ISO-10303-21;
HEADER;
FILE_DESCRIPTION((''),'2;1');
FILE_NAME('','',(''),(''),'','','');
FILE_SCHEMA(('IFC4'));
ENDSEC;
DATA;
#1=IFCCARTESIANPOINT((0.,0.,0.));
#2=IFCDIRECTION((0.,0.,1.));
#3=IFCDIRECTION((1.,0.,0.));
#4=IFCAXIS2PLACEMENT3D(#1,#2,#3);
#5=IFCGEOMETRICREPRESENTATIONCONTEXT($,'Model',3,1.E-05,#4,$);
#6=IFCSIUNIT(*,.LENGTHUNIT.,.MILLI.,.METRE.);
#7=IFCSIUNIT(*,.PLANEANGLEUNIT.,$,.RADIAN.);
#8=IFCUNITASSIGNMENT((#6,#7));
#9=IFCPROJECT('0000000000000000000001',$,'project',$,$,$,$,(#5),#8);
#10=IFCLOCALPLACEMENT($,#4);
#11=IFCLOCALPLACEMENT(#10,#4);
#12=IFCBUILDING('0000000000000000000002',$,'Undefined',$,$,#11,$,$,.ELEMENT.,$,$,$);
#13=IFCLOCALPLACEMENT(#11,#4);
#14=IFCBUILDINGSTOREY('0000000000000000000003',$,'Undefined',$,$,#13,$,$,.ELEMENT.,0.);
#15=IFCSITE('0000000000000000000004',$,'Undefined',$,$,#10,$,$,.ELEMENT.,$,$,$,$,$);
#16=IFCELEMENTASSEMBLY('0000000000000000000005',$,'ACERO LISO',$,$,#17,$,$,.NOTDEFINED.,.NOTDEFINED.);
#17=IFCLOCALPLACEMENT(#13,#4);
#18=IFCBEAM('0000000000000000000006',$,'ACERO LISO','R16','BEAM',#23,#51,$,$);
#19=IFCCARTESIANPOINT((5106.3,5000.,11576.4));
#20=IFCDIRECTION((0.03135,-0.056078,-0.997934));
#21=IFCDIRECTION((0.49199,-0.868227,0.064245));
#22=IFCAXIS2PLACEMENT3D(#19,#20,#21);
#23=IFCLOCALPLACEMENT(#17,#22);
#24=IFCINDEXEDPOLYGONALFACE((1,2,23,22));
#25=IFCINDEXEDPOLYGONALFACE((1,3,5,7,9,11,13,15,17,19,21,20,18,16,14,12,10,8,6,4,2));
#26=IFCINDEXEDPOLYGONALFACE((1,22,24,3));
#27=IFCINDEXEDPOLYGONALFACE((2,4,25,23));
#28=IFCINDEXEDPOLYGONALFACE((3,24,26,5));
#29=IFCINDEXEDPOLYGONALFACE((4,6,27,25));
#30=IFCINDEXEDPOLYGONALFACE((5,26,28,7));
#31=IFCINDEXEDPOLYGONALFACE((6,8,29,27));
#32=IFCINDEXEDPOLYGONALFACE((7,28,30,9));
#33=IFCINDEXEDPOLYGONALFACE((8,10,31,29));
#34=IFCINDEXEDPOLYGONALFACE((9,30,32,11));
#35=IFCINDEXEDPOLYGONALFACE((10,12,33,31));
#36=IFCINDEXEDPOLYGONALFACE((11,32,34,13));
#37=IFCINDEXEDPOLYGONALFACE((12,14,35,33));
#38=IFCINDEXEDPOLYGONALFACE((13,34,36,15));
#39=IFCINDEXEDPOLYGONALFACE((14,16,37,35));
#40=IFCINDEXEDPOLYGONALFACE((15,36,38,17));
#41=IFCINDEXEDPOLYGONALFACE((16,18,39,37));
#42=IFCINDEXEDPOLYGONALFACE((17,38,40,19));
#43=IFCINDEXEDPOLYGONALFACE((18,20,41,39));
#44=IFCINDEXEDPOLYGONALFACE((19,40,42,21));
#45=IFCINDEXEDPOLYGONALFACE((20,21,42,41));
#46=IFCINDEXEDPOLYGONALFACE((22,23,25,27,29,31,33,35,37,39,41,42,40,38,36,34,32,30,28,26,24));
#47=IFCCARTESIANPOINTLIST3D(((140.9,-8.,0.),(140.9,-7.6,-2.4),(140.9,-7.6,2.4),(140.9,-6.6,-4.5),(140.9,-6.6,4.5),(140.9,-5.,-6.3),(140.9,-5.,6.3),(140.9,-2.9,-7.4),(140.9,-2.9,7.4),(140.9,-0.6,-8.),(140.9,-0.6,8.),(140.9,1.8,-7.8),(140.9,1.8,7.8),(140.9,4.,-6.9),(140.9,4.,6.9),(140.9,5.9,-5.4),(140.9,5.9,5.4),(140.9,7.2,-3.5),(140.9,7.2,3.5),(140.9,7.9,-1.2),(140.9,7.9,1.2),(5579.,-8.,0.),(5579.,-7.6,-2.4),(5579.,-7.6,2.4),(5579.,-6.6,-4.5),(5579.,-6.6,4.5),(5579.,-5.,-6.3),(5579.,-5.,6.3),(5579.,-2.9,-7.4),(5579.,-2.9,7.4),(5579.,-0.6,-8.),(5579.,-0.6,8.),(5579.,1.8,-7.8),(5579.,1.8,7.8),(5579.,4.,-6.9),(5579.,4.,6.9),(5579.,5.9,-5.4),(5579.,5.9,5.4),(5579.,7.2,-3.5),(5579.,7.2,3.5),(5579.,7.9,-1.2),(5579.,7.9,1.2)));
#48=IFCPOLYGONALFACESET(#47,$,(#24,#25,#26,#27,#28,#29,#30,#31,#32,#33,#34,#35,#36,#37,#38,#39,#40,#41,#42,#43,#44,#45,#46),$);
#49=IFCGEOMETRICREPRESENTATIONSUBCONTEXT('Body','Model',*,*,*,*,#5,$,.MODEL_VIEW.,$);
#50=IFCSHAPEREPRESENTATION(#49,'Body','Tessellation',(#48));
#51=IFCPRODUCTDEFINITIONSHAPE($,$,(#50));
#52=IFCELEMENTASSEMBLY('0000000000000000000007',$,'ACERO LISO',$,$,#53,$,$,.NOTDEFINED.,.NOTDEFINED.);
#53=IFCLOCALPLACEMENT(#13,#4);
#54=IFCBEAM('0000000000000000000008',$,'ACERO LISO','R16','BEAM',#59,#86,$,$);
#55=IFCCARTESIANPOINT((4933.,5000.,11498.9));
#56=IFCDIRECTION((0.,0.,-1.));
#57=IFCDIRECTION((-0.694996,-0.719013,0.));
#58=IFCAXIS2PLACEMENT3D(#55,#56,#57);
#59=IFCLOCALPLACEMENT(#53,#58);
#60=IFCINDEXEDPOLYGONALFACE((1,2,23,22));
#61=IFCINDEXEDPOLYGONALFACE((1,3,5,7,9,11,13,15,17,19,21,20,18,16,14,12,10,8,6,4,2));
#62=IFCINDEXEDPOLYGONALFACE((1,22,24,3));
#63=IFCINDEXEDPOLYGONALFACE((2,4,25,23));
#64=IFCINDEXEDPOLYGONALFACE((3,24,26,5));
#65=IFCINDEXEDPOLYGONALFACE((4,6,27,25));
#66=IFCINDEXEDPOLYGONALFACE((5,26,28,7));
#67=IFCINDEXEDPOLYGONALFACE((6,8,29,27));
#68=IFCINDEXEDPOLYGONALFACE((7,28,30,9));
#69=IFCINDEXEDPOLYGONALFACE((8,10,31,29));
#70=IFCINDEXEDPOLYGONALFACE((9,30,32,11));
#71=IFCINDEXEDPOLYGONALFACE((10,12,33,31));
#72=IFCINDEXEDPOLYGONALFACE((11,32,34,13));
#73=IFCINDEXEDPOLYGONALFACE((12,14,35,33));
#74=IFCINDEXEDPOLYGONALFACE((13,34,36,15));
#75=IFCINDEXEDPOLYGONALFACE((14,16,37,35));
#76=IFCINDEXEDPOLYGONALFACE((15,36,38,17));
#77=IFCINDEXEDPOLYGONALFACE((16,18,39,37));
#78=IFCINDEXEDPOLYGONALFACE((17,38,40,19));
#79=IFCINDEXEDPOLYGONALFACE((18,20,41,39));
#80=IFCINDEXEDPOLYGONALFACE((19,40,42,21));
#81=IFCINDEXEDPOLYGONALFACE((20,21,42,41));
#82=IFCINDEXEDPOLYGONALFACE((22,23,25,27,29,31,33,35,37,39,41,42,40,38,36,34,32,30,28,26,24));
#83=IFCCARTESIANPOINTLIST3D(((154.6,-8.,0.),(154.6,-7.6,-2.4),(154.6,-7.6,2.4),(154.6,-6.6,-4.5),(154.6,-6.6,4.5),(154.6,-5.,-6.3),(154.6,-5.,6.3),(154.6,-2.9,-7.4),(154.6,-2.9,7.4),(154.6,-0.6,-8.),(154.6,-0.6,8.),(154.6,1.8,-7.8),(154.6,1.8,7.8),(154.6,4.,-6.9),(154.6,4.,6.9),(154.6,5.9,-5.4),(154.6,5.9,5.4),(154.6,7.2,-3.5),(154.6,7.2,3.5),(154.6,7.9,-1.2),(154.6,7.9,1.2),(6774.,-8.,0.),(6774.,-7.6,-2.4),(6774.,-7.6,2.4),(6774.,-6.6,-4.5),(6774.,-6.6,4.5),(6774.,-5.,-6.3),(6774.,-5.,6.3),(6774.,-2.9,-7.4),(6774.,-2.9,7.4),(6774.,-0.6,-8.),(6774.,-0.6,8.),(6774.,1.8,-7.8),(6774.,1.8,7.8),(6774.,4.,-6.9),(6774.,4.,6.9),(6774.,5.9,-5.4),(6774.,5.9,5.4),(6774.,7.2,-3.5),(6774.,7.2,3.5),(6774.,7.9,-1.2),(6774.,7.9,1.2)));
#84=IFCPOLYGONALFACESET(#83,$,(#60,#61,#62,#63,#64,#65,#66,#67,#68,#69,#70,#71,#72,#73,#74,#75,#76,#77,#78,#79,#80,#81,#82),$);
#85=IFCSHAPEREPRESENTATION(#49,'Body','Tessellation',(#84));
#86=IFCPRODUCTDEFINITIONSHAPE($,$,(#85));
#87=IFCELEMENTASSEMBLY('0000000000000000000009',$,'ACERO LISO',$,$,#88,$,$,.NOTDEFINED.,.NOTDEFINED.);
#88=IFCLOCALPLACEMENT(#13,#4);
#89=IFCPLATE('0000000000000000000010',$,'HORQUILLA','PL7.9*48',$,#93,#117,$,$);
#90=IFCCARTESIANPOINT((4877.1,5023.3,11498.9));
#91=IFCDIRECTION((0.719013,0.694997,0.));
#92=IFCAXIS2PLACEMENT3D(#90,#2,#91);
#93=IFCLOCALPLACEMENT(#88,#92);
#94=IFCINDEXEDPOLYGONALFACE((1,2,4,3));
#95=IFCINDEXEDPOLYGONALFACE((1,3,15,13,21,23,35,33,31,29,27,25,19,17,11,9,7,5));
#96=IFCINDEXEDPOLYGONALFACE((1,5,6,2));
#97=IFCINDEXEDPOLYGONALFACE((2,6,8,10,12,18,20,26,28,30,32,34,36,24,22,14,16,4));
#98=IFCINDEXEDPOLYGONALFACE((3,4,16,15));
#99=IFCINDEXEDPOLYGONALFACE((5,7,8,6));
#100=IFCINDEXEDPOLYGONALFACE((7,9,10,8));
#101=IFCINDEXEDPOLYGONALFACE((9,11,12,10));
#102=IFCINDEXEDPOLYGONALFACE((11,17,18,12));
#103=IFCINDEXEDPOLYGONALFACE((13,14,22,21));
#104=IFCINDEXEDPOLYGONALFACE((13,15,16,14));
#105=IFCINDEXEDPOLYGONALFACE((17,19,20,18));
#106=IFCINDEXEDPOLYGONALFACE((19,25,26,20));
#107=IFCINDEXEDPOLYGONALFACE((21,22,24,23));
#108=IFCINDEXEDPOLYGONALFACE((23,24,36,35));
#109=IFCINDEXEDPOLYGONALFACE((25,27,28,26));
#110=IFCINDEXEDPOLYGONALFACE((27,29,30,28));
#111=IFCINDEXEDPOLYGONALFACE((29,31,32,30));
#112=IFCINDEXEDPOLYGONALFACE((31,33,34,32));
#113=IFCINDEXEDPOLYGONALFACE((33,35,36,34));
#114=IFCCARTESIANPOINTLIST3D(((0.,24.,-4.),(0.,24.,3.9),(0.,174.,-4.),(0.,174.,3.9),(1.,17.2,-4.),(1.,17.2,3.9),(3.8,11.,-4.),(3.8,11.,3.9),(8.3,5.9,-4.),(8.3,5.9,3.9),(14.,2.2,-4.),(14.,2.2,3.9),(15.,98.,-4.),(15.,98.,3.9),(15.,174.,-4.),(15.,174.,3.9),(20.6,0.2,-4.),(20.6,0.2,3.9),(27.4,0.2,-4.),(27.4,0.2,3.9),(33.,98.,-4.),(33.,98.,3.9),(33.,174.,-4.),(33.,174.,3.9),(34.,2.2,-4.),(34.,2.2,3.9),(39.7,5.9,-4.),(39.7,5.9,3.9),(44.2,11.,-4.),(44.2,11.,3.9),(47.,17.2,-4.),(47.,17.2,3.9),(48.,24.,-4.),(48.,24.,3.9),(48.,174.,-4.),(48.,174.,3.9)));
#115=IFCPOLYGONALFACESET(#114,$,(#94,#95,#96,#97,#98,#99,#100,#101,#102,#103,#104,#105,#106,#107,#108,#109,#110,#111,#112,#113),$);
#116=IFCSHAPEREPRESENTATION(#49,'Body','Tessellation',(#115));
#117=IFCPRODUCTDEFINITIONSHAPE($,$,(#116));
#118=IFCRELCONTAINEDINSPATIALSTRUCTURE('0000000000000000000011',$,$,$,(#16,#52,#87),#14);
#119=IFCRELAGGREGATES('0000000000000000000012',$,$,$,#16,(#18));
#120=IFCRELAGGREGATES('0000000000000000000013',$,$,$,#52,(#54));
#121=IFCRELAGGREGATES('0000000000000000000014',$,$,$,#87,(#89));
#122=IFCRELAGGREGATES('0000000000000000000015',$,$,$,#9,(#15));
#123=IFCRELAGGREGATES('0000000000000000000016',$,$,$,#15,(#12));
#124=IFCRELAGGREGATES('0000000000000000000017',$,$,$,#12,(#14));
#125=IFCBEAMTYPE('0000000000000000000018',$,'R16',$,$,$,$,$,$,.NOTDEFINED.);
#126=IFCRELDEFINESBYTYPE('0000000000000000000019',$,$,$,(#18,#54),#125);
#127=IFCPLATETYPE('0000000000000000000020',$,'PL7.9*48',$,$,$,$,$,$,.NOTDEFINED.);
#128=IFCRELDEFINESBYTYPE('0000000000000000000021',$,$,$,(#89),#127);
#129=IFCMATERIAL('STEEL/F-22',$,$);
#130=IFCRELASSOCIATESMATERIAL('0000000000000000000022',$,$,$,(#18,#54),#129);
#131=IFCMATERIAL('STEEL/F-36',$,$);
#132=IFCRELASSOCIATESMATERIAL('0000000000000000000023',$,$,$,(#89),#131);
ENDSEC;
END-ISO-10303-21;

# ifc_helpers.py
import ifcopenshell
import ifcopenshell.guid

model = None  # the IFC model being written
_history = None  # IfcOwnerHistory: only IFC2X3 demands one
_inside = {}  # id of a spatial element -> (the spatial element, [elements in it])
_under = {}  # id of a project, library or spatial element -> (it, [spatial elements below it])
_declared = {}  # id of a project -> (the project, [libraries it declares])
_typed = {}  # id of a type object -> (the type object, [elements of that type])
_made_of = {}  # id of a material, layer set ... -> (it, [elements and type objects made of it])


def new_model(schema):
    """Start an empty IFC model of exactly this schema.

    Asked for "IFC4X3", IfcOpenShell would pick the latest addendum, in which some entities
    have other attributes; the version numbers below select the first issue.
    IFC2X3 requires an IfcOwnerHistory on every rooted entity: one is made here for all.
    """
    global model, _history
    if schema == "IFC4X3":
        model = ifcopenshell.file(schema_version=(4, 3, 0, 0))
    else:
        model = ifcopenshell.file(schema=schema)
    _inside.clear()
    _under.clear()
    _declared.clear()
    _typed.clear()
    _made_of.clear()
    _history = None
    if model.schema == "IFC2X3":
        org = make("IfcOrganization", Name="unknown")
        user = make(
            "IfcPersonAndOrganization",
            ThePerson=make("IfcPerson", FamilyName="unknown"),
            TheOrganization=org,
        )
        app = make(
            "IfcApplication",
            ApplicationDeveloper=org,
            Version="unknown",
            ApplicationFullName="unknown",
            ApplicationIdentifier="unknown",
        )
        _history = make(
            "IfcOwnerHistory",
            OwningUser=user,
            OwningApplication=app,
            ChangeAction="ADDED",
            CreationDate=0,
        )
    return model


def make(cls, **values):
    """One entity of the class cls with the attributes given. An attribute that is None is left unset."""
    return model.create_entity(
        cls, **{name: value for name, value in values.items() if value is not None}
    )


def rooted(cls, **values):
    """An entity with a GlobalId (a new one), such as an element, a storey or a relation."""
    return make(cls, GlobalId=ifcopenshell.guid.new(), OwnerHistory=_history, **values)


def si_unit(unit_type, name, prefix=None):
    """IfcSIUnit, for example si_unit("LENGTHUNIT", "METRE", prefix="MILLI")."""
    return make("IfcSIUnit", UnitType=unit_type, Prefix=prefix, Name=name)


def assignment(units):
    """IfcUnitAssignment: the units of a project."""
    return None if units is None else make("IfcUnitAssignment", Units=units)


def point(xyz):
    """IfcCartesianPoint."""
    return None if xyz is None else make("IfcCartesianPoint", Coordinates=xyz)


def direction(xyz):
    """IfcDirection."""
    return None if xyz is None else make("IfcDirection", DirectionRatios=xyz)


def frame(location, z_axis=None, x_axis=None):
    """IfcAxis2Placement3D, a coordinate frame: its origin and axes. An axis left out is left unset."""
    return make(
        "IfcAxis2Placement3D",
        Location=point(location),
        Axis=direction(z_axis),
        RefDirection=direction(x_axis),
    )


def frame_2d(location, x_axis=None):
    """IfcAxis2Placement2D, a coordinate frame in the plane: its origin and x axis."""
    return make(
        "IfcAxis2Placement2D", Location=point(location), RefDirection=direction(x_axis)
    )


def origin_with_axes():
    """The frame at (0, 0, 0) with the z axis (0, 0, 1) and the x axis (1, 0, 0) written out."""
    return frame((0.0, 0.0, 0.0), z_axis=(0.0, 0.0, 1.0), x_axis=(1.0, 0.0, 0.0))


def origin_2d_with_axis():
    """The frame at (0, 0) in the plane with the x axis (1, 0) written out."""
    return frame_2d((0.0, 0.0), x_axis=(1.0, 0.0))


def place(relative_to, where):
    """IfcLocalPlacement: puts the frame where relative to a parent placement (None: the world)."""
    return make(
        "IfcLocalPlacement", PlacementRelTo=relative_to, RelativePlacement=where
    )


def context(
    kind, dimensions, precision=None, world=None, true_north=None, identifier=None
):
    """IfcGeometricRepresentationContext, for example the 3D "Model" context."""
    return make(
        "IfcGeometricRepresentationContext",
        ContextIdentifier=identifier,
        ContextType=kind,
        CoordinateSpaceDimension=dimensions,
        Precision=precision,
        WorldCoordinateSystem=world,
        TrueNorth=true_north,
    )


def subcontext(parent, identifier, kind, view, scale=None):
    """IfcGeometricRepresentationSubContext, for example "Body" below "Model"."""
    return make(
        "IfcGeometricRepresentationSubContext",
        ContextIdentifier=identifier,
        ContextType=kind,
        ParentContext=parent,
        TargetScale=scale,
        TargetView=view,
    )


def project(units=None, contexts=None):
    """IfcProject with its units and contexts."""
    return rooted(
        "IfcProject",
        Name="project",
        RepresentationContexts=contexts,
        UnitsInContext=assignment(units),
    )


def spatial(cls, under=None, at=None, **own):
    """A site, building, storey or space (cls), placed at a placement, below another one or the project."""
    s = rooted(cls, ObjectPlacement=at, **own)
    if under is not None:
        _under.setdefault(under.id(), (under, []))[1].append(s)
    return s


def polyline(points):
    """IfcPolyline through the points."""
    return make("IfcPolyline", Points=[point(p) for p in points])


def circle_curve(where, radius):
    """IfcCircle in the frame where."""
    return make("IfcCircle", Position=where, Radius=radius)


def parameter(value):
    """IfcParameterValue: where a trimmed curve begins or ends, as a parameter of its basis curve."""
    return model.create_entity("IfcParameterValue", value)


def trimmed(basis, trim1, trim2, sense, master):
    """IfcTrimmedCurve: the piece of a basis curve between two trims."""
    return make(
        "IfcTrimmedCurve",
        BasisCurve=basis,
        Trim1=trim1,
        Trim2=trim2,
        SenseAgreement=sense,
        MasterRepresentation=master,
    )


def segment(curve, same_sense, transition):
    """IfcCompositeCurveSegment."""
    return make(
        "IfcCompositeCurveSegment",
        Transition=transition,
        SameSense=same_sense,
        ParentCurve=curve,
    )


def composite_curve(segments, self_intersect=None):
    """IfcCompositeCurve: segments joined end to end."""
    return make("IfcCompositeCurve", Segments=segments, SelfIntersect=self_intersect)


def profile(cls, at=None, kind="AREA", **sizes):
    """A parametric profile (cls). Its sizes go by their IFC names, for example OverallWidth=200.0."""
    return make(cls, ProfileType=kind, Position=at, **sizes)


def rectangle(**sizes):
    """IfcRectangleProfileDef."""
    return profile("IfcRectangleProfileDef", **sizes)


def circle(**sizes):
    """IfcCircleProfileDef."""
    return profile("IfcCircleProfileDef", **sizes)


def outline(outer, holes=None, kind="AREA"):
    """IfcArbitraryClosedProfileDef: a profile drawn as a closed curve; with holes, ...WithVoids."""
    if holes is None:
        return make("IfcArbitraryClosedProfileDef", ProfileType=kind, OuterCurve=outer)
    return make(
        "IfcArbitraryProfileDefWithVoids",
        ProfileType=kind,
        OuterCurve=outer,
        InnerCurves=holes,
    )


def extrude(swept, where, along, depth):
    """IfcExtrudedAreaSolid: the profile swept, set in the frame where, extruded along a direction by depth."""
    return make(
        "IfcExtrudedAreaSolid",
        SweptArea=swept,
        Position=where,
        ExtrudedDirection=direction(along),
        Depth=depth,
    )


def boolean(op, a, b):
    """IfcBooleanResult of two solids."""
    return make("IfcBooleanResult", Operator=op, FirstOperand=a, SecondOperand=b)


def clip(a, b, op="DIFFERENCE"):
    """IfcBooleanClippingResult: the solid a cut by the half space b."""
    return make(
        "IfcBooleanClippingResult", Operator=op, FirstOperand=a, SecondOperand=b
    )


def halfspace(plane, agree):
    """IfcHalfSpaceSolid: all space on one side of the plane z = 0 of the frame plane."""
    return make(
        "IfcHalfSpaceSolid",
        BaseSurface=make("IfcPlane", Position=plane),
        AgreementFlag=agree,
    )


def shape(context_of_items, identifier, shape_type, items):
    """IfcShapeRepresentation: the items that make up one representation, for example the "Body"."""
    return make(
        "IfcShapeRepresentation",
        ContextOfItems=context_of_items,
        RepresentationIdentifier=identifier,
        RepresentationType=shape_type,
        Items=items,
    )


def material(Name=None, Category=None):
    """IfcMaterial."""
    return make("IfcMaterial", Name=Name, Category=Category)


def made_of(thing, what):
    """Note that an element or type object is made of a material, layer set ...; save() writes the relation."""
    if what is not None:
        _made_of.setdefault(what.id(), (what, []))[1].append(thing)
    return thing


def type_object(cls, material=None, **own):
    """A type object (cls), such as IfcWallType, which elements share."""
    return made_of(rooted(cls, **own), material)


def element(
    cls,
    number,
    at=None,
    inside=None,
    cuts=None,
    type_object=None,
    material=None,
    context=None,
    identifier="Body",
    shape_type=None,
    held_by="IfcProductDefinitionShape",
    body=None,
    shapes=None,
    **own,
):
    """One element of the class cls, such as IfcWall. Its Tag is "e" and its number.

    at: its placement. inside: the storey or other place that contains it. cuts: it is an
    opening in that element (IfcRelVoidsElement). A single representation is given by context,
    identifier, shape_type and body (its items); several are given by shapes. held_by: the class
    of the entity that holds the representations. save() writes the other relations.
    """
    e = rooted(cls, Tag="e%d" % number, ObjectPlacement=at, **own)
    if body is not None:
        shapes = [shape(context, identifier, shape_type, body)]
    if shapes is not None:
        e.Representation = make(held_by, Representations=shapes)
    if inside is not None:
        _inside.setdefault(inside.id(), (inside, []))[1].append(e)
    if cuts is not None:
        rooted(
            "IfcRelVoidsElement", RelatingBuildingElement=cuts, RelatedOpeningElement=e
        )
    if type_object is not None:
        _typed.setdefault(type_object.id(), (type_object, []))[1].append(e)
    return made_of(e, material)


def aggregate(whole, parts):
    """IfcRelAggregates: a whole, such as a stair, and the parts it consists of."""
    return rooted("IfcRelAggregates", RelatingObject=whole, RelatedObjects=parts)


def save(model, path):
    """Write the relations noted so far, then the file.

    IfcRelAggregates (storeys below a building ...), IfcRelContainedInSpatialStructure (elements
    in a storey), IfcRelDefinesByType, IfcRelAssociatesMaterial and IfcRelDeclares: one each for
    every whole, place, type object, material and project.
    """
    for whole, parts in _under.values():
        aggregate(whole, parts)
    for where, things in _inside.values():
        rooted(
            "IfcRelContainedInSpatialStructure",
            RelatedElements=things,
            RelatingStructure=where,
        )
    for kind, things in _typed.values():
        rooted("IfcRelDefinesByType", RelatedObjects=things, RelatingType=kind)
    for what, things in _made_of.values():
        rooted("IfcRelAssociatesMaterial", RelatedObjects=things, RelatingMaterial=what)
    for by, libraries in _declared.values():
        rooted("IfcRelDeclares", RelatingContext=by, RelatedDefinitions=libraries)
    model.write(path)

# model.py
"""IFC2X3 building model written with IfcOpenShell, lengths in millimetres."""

from ifc_helpers import new_model, si_unit, frame, frame_2d, origin_with_axes, origin_2d_with_axis, place, context, subcontext, project, spatial, polyline, circle_curve, parameter, trimmed, segment, composite_curve, rectangle, circle, outline, extrude, boolean, clip, halfspace, material, type_object, element, aggregate, save


model = new_model("IFC2X3")

# Units and contexts
model_context = context("Model", 3, precision=1e-05, world=origin_with_axes())
body_context = subcontext(model_context, "Body", "Model", "MODEL_VIEW")
ifc_project = project(units=[si_unit("LENGTHUNIT", "METRE", prefix="MILLI"), si_unit("PLANEANGLEUNIT", "RADIAN")], contexts=[model_context])

# Site, building, storey
site_placement = place(None, origin_with_axes())
site = spatial("IfcSite", under=ifc_project, at=site_placement, Name="Undefined", CompositionType="ELEMENT")
building_placement = place(site_placement, origin_with_axes())
building = spatial("IfcBuilding", under=site, at=building_placement, Name="Undefined", CompositionType="ELEMENT")
storey_placement = place(building_placement, origin_with_axes())
storey = spatial("IfcBuildingStorey", under=building, at=storey_placement, Name="Undefined", CompositionType="ELEMENT", Elevation=0.0)

# Element assemblies, beams
assembly_1_placement = place(storey_placement, origin_with_axes())
assembly_1 = element("IfcElementAssembly", 1, at=assembly_1_placement, inside=storey, Name="ACERO LISO", AssemblyPlace="NOTDEFINED", PredefinedType="NOTDEFINED")
ifc_material_1 = material(Name="STEEL/F-22")
beam_type_1 = type_object("IfcBeamType", Name="R16", PredefinedType="NOTDEFINED")
beam_1_placement = place(assembly_1_placement, frame((5106.3, 5000.0, 11576.4), z_axis=(0.03135, -0.056078, -0.997934), x_axis=(0.49199, -0.868227, 0.064245)))
beam_1 = element("IfcBeam", 2, at=beam_1_placement, type_object=beam_type_1, material=ifc_material_1, Name="ACERO LISO", Description="R16", ObjectType="BEAM", context=body_context, shape_type="Clipping", body=[
    clip(extrude(circle(Radius=8.0, at=origin_2d_with_axis()), frame((5579.0, 0.0, 0.0), z_axis=(-1.0, 0.0, 0.0), x_axis=(0.0, -1.0, 0.0)), (0.0, 0.0, 1.0), 5579.0), halfspace(frame((140.9, 0.0, 0.0), z_axis=(1.0, 0.0, 0.0), x_axis=(0.0, -0.097702, 0.995216)), True)),
])
aggregate(assembly_1, [beam_1])
assembly_2_placement = place(storey_placement, origin_with_axes())
assembly_2 = element("IfcElementAssembly", 3, at=assembly_2_placement, inside=storey, Name="ACERO LISO", AssemblyPlace="NOTDEFINED", PredefinedType="NOTDEFINED")
beam_2_placement = place(assembly_2_placement, frame((4933.0, 5000.0, 11498.9), z_axis=(0.0, 0.0, -1.0), x_axis=(-0.694996, -0.719013, 0.0)))
beam_2 = element("IfcBeam", 4, at=beam_2_placement, type_object=beam_type_1, material=ifc_material_1, Name="ACERO LISO", Description="R16", ObjectType="BEAM", context=body_context, shape_type="Clipping", body=[
    clip(extrude(circle(Radius=8.0, at=origin_2d_with_axis()), frame((6774.0, 0.0, 0.0), z_axis=(-1.0, 0.0, 0.0), x_axis=(0.0, -1.0, 0.0)), (0.0, 0.0, 1.0), 6774.0), halfspace(frame((154.6, 0.0, 0.0), z_axis=(1.0, 0.0, 0.0), x_axis=(0.0, 0.0, 1.0)), True)),
])
aggregate(assembly_2, [beam_2])
ifc_material_2 = material(Name="STEEL/F-36")

# Element assembly, plate
plate_type_1 = type_object("IfcPlateType", Name="PL7.9*48", PredefinedType="NOTDEFINED")
assembly_3_placement = place(storey_placement, origin_with_axes())
assembly_3 = element("IfcElementAssembly", 5, at=assembly_3_placement, inside=storey, Name="ACERO LISO", AssemblyPlace="NOTDEFINED", PredefinedType="NOTDEFINED")
plate_1_placement = place(assembly_3_placement, frame((4877.1, 5023.3, 11498.9), z_axis=(0.0, 0.0, 1.0), x_axis=(0.719013, 0.694997, 0.0)))
plate_1 = element("IfcPlate", 6, at=plate_1_placement, type_object=plate_type_1, material=ifc_material_2, Name="HORQUILLA", Description="PL7.9*48", context=body_context, shape_type="CSG", body=[
    boolean("DIFFERENCE", extrude(outline(composite_curve([segment(trimmed(circle_curve(frame_2d((24.0, 24.0), x_axis=(-1.0, 0.0)), 24.0), [parameter(0.0)], [parameter(1.570796)], True, "PARAMETER"), True, "CONTINUOUS"), segment(polyline([(24.0, 0.0), (24.0, 0.0)]), True, "CONTINUOUS"), segment(trimmed(circle_curve(frame_2d((24.0, 24.0), x_axis=(0.0, -1.0)), 24.0), [parameter(0.0)], [parameter(1.570796)], True, "PARAMETER"), True, "CONTINUOUS"), segment(polyline([(48.0, 24.0), (48.0, 174.0), (0.0, 174.0), (0.0, 24.0)]), True, "CONTINUOUS")], self_intersect=True)), frame((0.0, 0.0, -4.0), z_axis=(0.0, 0.0, 1.0), x_axis=(1.0, 0.0, 0.0)), (0.0, 0.0, 1.0), 7.9), extrude(rectangle(XDim=18.0, YDim=18.0, at=origin_2d_with_axis()), frame((24.0, 274.0, 0.0), z_axis=(0.0, -1.0, 0.0), x_axis=(-1.0, 0.0, 0.0)), (0.0, 0.0, 1.0), 176.0)),
])

aggregate(assembly_3, [plate_1])

save(model, "model.ifc")
